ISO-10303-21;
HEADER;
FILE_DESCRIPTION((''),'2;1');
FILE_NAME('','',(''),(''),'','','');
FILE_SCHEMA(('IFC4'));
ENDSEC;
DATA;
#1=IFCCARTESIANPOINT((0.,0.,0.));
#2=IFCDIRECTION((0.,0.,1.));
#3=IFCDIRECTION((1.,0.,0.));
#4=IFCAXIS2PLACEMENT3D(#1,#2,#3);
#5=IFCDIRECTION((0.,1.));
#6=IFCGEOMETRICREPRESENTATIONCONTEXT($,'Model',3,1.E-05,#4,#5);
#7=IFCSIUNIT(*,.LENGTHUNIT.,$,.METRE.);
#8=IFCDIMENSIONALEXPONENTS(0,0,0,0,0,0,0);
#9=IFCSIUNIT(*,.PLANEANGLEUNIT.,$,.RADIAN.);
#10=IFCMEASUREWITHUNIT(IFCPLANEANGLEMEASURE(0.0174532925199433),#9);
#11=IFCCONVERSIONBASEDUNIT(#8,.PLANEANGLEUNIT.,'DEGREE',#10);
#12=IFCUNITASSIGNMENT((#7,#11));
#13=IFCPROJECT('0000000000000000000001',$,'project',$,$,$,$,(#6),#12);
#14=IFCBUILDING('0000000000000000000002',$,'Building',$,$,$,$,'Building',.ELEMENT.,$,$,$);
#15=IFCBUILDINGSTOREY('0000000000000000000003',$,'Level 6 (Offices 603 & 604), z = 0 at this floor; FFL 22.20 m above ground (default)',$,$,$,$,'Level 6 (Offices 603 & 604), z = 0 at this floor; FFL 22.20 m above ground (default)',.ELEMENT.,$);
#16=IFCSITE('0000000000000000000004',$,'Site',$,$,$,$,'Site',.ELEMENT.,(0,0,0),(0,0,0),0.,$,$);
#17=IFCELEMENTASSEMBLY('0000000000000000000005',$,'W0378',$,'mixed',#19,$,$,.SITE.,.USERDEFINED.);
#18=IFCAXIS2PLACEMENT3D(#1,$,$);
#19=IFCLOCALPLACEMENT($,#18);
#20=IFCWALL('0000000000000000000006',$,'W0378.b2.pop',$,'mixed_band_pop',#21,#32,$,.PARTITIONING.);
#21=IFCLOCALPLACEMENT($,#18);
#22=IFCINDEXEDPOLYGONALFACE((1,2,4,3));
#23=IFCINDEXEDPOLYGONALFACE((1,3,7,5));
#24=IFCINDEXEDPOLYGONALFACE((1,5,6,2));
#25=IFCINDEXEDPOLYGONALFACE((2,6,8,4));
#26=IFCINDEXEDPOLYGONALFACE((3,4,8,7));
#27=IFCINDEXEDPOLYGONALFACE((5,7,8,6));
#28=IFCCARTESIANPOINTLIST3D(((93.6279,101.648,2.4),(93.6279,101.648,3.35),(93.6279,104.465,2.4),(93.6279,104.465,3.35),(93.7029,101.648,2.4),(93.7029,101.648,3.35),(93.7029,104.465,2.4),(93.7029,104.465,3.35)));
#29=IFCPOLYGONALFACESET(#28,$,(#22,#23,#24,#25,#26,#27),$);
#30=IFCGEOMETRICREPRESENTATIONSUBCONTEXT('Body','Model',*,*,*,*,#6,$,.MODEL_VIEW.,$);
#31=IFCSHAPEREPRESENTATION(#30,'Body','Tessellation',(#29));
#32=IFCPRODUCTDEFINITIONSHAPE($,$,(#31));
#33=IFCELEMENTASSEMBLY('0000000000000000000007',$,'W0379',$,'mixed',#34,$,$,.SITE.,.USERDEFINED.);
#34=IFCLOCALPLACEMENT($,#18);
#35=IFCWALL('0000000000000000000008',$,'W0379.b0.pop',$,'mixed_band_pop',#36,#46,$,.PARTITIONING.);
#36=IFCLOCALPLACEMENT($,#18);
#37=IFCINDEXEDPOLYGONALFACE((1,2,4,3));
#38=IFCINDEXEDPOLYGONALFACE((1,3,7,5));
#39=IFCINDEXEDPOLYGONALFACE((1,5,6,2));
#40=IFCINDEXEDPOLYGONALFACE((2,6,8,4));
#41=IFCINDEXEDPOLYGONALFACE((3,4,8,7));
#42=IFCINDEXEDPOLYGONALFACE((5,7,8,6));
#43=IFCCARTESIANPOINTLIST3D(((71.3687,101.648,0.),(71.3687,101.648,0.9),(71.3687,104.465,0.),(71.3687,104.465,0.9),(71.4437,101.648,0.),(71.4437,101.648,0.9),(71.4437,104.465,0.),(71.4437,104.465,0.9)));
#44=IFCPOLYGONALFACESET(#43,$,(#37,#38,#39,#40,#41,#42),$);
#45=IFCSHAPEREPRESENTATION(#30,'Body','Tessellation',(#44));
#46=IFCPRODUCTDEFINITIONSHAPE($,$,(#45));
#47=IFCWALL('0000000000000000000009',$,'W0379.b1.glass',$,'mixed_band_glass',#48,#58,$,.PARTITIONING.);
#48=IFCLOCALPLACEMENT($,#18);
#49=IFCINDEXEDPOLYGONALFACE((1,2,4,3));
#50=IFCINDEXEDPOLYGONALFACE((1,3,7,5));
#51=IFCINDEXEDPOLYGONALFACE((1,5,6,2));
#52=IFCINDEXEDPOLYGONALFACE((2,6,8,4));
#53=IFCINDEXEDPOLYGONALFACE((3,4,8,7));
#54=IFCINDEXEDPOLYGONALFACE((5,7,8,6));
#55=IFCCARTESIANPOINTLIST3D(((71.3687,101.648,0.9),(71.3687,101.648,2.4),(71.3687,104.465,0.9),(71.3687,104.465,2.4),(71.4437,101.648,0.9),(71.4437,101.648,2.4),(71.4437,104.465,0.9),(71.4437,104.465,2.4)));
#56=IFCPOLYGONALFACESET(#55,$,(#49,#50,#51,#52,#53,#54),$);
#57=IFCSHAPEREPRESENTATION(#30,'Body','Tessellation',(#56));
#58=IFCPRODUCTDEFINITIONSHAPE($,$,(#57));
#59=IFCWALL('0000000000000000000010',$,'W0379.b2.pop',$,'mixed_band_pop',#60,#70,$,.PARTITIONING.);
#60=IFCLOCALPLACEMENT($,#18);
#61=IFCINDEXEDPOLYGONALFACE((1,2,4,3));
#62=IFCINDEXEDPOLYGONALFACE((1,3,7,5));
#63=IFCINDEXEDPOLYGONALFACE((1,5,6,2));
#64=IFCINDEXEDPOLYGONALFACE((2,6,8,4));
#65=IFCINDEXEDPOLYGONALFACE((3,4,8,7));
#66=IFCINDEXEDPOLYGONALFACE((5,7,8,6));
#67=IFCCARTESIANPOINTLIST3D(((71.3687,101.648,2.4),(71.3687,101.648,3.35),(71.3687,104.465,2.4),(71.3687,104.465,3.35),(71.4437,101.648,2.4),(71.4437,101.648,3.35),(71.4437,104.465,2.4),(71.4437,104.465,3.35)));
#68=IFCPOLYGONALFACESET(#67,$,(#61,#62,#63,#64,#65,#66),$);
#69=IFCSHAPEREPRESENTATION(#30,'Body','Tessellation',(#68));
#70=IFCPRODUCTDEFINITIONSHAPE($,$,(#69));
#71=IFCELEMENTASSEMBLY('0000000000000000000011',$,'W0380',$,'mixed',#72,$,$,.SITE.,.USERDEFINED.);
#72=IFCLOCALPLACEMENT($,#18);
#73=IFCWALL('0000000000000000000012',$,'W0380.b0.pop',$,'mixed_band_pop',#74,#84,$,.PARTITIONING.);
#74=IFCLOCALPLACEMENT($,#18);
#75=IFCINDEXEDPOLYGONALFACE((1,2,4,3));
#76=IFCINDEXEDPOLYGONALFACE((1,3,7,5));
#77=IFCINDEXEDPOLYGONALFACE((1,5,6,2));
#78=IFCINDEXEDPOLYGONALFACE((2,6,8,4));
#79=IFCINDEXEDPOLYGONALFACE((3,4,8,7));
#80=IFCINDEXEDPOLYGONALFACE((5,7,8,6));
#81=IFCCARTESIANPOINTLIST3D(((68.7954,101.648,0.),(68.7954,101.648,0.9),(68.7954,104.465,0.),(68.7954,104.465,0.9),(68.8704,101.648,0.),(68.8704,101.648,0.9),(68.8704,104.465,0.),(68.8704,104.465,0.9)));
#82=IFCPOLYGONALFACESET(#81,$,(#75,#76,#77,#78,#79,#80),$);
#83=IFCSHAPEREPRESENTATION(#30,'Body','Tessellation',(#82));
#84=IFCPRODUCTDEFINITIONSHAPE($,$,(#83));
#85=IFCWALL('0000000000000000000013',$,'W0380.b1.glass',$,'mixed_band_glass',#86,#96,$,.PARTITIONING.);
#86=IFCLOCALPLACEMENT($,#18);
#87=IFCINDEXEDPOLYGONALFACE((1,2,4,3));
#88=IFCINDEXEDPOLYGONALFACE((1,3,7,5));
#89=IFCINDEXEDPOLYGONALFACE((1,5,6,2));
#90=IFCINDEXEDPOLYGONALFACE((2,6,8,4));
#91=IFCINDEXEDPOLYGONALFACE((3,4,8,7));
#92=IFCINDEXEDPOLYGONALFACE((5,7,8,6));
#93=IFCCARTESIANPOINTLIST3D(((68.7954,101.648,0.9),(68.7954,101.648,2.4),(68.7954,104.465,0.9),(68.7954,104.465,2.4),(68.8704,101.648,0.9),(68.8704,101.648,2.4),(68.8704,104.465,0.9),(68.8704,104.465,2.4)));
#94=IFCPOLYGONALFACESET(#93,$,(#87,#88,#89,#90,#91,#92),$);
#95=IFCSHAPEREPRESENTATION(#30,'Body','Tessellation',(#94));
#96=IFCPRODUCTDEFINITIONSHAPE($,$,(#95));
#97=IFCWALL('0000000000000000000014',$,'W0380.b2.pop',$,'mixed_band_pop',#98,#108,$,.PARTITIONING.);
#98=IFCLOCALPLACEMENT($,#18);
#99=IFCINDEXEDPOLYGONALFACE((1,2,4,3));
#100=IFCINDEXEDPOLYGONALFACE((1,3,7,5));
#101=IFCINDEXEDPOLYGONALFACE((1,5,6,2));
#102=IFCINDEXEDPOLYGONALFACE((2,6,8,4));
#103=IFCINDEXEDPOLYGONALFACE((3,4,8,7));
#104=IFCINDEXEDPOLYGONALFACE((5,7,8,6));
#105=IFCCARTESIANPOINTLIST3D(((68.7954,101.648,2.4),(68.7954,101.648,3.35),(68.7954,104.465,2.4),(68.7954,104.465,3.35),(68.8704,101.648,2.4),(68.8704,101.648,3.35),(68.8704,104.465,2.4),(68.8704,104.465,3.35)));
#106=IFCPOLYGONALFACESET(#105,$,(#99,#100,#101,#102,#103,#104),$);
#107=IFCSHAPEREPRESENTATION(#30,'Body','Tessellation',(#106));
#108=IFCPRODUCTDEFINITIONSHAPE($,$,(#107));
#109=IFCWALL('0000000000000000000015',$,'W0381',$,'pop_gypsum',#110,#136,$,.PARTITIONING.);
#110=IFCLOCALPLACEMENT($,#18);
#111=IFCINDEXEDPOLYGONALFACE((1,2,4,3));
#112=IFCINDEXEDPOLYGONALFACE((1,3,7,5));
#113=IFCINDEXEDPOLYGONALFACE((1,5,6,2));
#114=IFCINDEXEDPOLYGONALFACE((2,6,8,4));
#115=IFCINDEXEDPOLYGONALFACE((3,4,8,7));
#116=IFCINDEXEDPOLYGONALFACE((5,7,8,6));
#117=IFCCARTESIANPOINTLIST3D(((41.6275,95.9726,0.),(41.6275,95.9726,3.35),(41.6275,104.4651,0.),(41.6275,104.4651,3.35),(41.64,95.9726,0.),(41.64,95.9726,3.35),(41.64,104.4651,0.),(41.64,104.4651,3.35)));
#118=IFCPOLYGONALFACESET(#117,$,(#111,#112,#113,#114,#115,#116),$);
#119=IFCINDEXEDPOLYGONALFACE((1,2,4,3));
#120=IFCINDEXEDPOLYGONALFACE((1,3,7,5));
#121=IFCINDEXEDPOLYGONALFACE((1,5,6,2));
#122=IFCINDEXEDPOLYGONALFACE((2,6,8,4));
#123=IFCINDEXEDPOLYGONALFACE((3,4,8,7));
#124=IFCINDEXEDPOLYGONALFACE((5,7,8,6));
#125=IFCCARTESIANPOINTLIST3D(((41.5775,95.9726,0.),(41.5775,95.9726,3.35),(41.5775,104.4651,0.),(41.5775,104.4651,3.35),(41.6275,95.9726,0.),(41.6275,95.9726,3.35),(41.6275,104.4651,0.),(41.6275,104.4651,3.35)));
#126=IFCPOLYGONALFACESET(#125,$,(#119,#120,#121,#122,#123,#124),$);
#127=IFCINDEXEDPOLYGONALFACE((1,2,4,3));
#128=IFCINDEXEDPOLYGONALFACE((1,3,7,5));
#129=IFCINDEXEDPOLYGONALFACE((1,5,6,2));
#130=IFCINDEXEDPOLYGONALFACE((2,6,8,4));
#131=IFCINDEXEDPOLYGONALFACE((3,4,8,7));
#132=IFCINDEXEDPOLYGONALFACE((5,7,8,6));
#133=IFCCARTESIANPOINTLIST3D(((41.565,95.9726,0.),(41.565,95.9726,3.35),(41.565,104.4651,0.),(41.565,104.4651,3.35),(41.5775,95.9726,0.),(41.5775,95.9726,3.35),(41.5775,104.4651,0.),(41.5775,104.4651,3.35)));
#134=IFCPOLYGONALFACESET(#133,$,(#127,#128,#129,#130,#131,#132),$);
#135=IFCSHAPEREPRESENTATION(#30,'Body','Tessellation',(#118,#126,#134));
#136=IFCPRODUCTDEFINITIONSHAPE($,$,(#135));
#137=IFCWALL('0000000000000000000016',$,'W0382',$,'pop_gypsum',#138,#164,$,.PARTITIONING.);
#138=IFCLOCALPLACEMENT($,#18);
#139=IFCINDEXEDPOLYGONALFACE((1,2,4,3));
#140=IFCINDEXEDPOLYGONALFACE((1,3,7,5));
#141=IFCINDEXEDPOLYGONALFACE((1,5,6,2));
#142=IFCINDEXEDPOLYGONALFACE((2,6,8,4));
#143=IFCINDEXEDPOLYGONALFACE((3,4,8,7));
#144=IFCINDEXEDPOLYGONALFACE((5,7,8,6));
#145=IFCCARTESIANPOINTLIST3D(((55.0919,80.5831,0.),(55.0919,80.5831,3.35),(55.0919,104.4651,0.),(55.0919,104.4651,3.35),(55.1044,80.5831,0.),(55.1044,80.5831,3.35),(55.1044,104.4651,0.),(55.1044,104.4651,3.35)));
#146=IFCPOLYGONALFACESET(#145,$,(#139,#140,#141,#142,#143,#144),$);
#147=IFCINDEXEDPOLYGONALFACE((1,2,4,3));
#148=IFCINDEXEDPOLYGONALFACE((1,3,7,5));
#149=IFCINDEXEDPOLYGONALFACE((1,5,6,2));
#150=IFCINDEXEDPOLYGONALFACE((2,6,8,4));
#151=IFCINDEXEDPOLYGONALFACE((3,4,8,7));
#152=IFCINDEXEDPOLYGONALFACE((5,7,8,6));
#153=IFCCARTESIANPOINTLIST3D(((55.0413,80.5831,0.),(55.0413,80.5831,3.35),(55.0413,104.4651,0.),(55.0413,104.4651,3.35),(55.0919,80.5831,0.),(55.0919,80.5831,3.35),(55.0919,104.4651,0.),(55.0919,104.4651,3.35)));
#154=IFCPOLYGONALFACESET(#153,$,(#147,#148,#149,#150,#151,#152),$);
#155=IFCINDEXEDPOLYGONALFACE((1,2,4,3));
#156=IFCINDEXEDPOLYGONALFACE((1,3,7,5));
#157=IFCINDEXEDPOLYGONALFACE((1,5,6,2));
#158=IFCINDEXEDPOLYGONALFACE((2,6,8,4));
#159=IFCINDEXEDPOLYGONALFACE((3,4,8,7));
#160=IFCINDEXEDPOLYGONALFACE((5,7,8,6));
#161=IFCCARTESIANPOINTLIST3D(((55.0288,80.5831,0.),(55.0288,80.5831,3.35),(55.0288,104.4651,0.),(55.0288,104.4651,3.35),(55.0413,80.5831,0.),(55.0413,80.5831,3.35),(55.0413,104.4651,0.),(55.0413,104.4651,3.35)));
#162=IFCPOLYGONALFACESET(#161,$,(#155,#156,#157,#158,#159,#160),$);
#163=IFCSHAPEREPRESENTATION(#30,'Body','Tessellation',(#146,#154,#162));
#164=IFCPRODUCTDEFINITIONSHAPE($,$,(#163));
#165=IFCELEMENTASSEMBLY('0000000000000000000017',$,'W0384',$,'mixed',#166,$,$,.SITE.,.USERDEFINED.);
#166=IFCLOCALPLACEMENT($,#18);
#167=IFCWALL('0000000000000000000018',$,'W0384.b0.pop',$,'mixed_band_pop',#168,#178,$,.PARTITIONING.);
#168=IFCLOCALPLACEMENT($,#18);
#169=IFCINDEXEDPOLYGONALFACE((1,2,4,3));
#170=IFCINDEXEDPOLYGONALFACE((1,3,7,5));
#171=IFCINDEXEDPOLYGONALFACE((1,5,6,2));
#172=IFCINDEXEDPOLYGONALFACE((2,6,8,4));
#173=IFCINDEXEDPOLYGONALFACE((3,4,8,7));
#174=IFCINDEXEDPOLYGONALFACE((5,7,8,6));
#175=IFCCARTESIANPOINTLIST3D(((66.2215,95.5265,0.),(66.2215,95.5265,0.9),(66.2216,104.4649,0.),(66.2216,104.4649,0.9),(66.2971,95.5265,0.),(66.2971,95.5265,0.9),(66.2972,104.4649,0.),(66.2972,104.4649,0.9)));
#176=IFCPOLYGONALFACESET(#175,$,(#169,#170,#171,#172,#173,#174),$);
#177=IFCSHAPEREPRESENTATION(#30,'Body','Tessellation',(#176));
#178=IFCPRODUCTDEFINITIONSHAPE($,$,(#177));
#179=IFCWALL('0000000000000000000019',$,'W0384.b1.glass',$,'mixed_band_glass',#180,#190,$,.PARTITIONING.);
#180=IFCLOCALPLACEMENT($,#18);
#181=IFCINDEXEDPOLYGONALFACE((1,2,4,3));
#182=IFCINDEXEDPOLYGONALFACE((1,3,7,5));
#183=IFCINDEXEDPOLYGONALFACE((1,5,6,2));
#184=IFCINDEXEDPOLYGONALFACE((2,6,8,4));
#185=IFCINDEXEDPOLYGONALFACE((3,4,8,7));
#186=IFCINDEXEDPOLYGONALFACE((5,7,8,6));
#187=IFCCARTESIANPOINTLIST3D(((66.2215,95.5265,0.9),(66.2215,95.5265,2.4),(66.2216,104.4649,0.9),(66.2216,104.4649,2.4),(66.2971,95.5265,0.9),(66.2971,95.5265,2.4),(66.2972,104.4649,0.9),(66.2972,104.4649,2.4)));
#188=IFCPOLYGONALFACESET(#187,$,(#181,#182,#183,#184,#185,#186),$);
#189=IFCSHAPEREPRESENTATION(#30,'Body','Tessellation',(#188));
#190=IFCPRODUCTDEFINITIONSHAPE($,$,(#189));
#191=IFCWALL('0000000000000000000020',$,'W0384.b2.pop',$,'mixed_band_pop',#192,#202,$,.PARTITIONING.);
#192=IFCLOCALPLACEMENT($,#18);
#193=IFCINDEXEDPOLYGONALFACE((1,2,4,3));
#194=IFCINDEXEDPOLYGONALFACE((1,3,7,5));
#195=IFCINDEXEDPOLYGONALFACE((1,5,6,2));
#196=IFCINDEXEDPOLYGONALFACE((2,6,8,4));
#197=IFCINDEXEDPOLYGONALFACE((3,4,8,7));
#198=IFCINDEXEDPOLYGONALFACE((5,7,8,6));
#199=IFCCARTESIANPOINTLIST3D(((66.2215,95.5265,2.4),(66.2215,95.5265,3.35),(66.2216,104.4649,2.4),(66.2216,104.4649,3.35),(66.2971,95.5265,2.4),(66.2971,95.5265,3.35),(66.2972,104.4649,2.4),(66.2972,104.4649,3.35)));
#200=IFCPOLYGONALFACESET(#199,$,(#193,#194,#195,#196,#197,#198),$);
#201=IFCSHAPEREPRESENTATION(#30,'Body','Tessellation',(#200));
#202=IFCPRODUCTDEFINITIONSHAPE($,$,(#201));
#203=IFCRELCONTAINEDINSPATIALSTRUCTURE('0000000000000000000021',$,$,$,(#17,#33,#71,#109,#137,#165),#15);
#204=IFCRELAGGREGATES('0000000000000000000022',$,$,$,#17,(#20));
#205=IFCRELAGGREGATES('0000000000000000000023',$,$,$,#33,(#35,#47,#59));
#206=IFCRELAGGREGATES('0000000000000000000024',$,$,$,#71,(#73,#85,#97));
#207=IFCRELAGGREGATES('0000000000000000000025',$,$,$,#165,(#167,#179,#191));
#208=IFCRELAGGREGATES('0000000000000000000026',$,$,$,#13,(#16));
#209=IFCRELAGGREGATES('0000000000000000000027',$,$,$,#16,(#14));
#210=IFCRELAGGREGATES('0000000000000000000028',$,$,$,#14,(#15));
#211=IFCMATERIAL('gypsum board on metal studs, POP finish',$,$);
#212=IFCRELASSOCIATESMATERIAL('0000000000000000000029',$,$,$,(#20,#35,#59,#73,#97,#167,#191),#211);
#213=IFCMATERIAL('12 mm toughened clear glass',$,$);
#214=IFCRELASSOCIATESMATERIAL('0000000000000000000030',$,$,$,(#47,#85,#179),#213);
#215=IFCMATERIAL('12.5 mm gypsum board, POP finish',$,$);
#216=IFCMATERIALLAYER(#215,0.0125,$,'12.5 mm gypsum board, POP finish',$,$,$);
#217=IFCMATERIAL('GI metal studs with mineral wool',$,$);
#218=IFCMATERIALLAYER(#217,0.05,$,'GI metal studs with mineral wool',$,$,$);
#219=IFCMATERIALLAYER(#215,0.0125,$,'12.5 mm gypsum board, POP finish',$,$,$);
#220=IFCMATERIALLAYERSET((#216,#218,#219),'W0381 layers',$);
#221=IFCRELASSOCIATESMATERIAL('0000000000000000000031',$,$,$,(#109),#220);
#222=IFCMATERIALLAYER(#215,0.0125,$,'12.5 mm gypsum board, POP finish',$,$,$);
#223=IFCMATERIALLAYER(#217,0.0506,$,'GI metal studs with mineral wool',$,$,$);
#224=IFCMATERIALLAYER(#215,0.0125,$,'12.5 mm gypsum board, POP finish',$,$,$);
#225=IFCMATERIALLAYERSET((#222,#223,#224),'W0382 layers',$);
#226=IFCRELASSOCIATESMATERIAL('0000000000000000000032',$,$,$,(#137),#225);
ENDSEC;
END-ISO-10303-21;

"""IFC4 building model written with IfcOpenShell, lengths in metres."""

from ifc_helpers import new_model, entity, si_unit, converted_unit, direction, frame, frame_2d, origin_with_axes, place, context, subcontext, project, spatial, rectangle, extrude, material, layer, layer_set, layer_usage, element, aggregate, save


model = new_model("IFC4")

# Units and contexts
model_context = context("Model", 3, precision=1e-05, world=origin_with_axes(), true_north=direction((0.0, 1.0)))
body_context = subcontext(model_context, "Body", "Model", "MODEL_VIEW")
ifc_project = project(units=[si_unit("LENGTHUNIT", "METRE"), converted_unit("PLANEANGLEUNIT", "DEGREE", entity("IfcPlaneAngleMeasure", 0.0174532925199433), si_unit("PLANEANGLEUNIT", "RADIAN"), dimensions=[0, 0, 0, 0, 0, 0, 0])], contexts=[model_context])

# Site, building, storey
site = spatial("IfcSite", under=ifc_project, Name="Site", LongName="Site", CompositionType="ELEMENT", RefLatitude=(0, 0, 0), RefLongitude=(0, 0, 0), RefElevation=0.0)
building = spatial("IfcBuilding", under=site, Name="Building", LongName="Building", CompositionType="ELEMENT")
storey = spatial("IfcBuildingStorey", under=building, Name="Level 6 (Offices 603 & 604), z = 0 at this floor; FFL 22.20 m above ground (default)", LongName="Level 6 (Offices 603 & 604), z = 0 at this floor; FFL 22.20 m above ground (default)", CompositionType="ELEMENT")

# Element assembly, wall
assembly_1 = element("IfcElementAssembly", 1, inside=storey, Name="W0378", ObjectType="mixed", AssemblyPlace="SITE", PredefinedType="USERDEFINED")
ifc_material_1 = material(Name="gypsum board on metal studs, POP finish")
placement = place(None, origin_with_axes())
wall_1 = element("IfcWall", 2, at=placement, material=ifc_material_1, Name="W0378.b2.pop", ObjectType="mixed_band_pop", PredefinedType="PARTITIONING", context=body_context, shape_type="SweptSolid", body=[
    extrude(rectangle(XDim=2.817, YDim=0.075, at=frame_2d((0.0, 0.0), x_axis=(0.0, 1.0))), frame((93.6654, 103.0565, 2.4), z_axis=(0.0, 0.0, 1.0), x_axis=(1.0, 0.0, 0.0)), (0.0, 0.0, 1.0), 0.95),
])
aggregate(assembly_1, [wall_1])

# Element assemblies, walls
assembly_2 = element("IfcElementAssembly", 3, inside=storey, Name="W0379", ObjectType="mixed", AssemblyPlace="SITE", PredefinedType="USERDEFINED")
wall_2 = element("IfcWall", 4, at=placement, material=ifc_material_1, Name="W0379.b0.pop", ObjectType="mixed_band_pop", PredefinedType="PARTITIONING", context=body_context, shape_type="SweptSolid", body=[
    extrude(rectangle(XDim=2.817, YDim=0.075, at=frame_2d((0.0, 0.0), x_axis=(0.0, 1.0))), frame((71.4062, 103.0565, 0.0), z_axis=(0.0, 0.0, 1.0), x_axis=(1.0, 0.0, 0.0)), (0.0, 0.0, 1.0), 0.9),
])
ifc_material_2 = material(Name="12 mm toughened clear glass")
wall_3 = element("IfcWall", 5, at=placement, material=ifc_material_2, Name="W0379.b1.glass", ObjectType="mixed_band_glass", PredefinedType="PARTITIONING", context=body_context, shape_type="SweptSolid", body=[
    extrude(rectangle(XDim=2.817, YDim=0.075, at=frame_2d((0.0, 0.0), x_axis=(0.0, 1.0))), frame((71.4062, 103.0565, 0.9), z_axis=(0.0, 0.0, 1.0), x_axis=(1.0, 0.0, 0.0)), (0.0, 0.0, 1.0), 1.5),
])
wall_4 = element("IfcWall", 6, at=placement, material=ifc_material_1, Name="W0379.b2.pop", ObjectType="mixed_band_pop", PredefinedType="PARTITIONING", context=body_context, shape_type="SweptSolid", body=[
    extrude(rectangle(XDim=2.817, YDim=0.075, at=frame_2d((0.0, 0.0), x_axis=(0.0, 1.0))), frame((71.4062, 103.0565, 2.4), z_axis=(0.0, 0.0, 1.0), x_axis=(1.0, 0.0, 0.0)), (0.0, 0.0, 1.0), 0.95),
])
aggregate(assembly_2, [wall_2, wall_3, wall_4])
assembly_3 = element("IfcElementAssembly", 7, inside=storey, Name="W0380", ObjectType="mixed", AssemblyPlace="SITE", PredefinedType="USERDEFINED")
wall_5 = element("IfcWall", 8, at=placement, material=ifc_material_1, Name="W0380.b0.pop", ObjectType="mixed_band_pop", PredefinedType="PARTITIONING", context=body_context, shape_type="SweptSolid", body=[
    extrude(rectangle(XDim=2.817, YDim=0.075, at=frame_2d((0.0, 0.0), x_axis=(0.0, 1.0))), frame((68.8329, 103.0565, 0.0), z_axis=(0.0, 0.0, 1.0), x_axis=(1.0, 0.0, 0.0)), (0.0, 0.0, 1.0), 0.9),
])
wall_6 = element("IfcWall", 9, at=placement, material=ifc_material_2, Name="W0380.b1.glass", ObjectType="mixed_band_glass", PredefinedType="PARTITIONING", context=body_context, shape_type="SweptSolid", body=[
    extrude(rectangle(XDim=2.817, YDim=0.075, at=frame_2d((0.0, 0.0), x_axis=(0.0, 1.0))), frame((68.8329, 103.0565, 0.9), z_axis=(0.0, 0.0, 1.0), x_axis=(1.0, 0.0, 0.0)), (0.0, 0.0, 1.0), 1.5),
])
wall_7 = element("IfcWall", 10, at=placement, material=ifc_material_1, Name="W0380.b2.pop", ObjectType="mixed_band_pop", PredefinedType="PARTITIONING", context=body_context, shape_type="SweptSolid", body=[
    extrude(rectangle(XDim=2.817, YDim=0.075, at=frame_2d((0.0, 0.0), x_axis=(0.0, 1.0))), frame((68.8329, 103.0565, 2.4), z_axis=(0.0, 0.0, 1.0), x_axis=(1.0, 0.0, 0.0)), (0.0, 0.0, 1.0), 0.95),
])
aggregate(assembly_3, [wall_5, wall_6, wall_7])

# Walls
ifc_material_3 = material(Name="12.5 mm gypsum board, POP finish")
ifc_layer_1 = layer(ifc_material_3, 0.0125, Name="12.5 mm gypsum board, POP finish")
ifc_material_4 = material(Name="GI metal studs with mineral wool")
ifc_layer_2 = layer(ifc_material_4, 0.05, Name="GI metal studs with mineral wool")
ifc_layer_3 = layer(ifc_material_3, 0.0125, Name="12.5 mm gypsum board, POP finish")
ifc_layer_set_1 = layer_set([ifc_layer_1, ifc_layer_2, ifc_layer_3], Name="W0381 layers")
ifc_layer_usage_1 = layer_usage(ifc_layer_set_1, "AXIS2", "POSITIVE", -0.0375)
element("IfcWall", 11, at=placement, inside=storey, material=ifc_layer_usage_1, Name="W0381", ObjectType="pop_gypsum", PredefinedType="PARTITIONING", context=body_context, shape_type="SweptSolid", body=[
    extrude(rectangle(XDim=8.4925, YDim=0.0125, at=frame_2d((0.0, 0.0), x_axis=(0.0, 1.0))), frame((41.6337, 100.2189, 0.0), z_axis=(0.0, 0.0, 1.0), x_axis=(1.0, 0.0, 0.0)), (0.0, 0.0, 1.0), 3.35),
    extrude(rectangle(XDim=8.4925, YDim=0.05, at=frame_2d((-0.0312, 0.0), x_axis=(0.0, 1.0))), frame((41.6337, 100.2189, 0.0), z_axis=(0.0, 0.0, 1.0), x_axis=(1.0, 0.0, 0.0)), (0.0, 0.0, 1.0), 3.35),
    extrude(rectangle(XDim=8.4925, YDim=0.0125, at=frame_2d((-0.0625, 0.0), x_axis=(0.0, 1.0))), frame((41.6337, 100.2189, 0.0), z_axis=(0.0, 0.0, 1.0), x_axis=(1.0, 0.0, 0.0)), (0.0, 0.0, 1.0), 3.35),
])
ifc_layer_4 = layer(ifc_material_3, 0.0125, Name="12.5 mm gypsum board, POP finish")
ifc_layer_5 = layer(ifc_material_4, 0.0506, Name="GI metal studs with mineral wool")
ifc_layer_6 = layer(ifc_material_3, 0.0125, Name="12.5 mm gypsum board, POP finish")
ifc_layer_set_2 = layer_set([ifc_layer_4, ifc_layer_5, ifc_layer_6], Name="W0382 layers")
ifc_layer_usage_2 = layer_usage(ifc_layer_set_2, "AXIS2", "POSITIVE", -0.0378)
element("IfcWall", 12, at=placement, inside=storey, material=ifc_layer_usage_2, Name="W0382", ObjectType="pop_gypsum", PredefinedType="PARTITIONING", context=body_context, shape_type="SweptSolid", body=[
    extrude(rectangle(XDim=23.882, YDim=0.0125, at=frame_2d((0.0, 0.0), x_axis=(0.0, 1.0))), frame((55.0981, 92.5241, 0.0), z_axis=(0.0, 0.0, 1.0), x_axis=(1.0, 0.0, 0.0)), (0.0, 0.0, 1.0), 3.35),
    extrude(rectangle(XDim=23.882, YDim=0.0506, at=frame_2d((-0.0315, 0.0), x_axis=(0.0, 1.0))), frame((55.0981, 92.5241, 0.0), z_axis=(0.0, 0.0, 1.0), x_axis=(1.0, 0.0, 0.0)), (0.0, 0.0, 1.0), 3.35),
    extrude(rectangle(XDim=23.882, YDim=0.0125, at=frame_2d((-0.0631, 0.0), x_axis=(0.0, 1.0))), frame((55.0981, 92.5241, 0.0), z_axis=(0.0, 0.0, 1.0), x_axis=(1.0, 0.0, 0.0)), (0.0, 0.0, 1.0), 3.35),
])

# Element assembly, walls
assembly_4 = element("IfcElementAssembly", 13, inside=storey, Name="W0384", ObjectType="mixed", AssemblyPlace="SITE", PredefinedType="USERDEFINED")
wall_8 = element("IfcWall", 14, at=placement, material=ifc_material_1, Name="W0384.b0.pop", ObjectType="mixed_band_pop", PredefinedType="PARTITIONING", context=body_context, shape_type="SweptSolid", body=[
    extrude(rectangle(XDim=8.9384, YDim=0.0756, at=frame_2d((0.0, 0.0), x_axis=(0.000011, 1.0))), frame((66.2593, 99.9957, 0.0), z_axis=(0.0, 0.0, 1.0), x_axis=(1.0, 0.0, 0.0)), (0.0, 0.0, 1.0), 0.9),
])
wall_9 = element("IfcWall", 15, at=placement, material=ifc_material_2, Name="W0384.b1.glass", ObjectType="mixed_band_glass", PredefinedType="PARTITIONING", context=body_context, shape_type="SweptSolid", body=[
    extrude(rectangle(XDim=8.9384, YDim=0.0756, at=frame_2d((0.0, 0.0), x_axis=(0.000011, 1.0))), frame((66.2593, 99.9957, 0.9), z_axis=(0.0, 0.0, 1.0), x_axis=(1.0, 0.0, 0.0)), (0.0, 0.0, 1.0), 1.5),
])
wall_10 = element("IfcWall", 16, at=placement, material=ifc_material_1, Name="W0384.b2.pop", ObjectType="mixed_band_pop", PredefinedType="PARTITIONING", context=body_context, shape_type="SweptSolid", body=[
    extrude(rectangle(XDim=8.9384, YDim=0.0756, at=frame_2d((0.0, 0.0), x_axis=(0.000011, 1.0))), frame((66.2593, 99.9957, 2.4), z_axis=(0.0, 0.0, 1.0), x_axis=(1.0, 0.0, 0.0)), (0.0, 0.0, 1.0), 0.95),
])
aggregate(assembly_4, [wall_8, wall_9, wall_10])

save(model, "model.ifc")
